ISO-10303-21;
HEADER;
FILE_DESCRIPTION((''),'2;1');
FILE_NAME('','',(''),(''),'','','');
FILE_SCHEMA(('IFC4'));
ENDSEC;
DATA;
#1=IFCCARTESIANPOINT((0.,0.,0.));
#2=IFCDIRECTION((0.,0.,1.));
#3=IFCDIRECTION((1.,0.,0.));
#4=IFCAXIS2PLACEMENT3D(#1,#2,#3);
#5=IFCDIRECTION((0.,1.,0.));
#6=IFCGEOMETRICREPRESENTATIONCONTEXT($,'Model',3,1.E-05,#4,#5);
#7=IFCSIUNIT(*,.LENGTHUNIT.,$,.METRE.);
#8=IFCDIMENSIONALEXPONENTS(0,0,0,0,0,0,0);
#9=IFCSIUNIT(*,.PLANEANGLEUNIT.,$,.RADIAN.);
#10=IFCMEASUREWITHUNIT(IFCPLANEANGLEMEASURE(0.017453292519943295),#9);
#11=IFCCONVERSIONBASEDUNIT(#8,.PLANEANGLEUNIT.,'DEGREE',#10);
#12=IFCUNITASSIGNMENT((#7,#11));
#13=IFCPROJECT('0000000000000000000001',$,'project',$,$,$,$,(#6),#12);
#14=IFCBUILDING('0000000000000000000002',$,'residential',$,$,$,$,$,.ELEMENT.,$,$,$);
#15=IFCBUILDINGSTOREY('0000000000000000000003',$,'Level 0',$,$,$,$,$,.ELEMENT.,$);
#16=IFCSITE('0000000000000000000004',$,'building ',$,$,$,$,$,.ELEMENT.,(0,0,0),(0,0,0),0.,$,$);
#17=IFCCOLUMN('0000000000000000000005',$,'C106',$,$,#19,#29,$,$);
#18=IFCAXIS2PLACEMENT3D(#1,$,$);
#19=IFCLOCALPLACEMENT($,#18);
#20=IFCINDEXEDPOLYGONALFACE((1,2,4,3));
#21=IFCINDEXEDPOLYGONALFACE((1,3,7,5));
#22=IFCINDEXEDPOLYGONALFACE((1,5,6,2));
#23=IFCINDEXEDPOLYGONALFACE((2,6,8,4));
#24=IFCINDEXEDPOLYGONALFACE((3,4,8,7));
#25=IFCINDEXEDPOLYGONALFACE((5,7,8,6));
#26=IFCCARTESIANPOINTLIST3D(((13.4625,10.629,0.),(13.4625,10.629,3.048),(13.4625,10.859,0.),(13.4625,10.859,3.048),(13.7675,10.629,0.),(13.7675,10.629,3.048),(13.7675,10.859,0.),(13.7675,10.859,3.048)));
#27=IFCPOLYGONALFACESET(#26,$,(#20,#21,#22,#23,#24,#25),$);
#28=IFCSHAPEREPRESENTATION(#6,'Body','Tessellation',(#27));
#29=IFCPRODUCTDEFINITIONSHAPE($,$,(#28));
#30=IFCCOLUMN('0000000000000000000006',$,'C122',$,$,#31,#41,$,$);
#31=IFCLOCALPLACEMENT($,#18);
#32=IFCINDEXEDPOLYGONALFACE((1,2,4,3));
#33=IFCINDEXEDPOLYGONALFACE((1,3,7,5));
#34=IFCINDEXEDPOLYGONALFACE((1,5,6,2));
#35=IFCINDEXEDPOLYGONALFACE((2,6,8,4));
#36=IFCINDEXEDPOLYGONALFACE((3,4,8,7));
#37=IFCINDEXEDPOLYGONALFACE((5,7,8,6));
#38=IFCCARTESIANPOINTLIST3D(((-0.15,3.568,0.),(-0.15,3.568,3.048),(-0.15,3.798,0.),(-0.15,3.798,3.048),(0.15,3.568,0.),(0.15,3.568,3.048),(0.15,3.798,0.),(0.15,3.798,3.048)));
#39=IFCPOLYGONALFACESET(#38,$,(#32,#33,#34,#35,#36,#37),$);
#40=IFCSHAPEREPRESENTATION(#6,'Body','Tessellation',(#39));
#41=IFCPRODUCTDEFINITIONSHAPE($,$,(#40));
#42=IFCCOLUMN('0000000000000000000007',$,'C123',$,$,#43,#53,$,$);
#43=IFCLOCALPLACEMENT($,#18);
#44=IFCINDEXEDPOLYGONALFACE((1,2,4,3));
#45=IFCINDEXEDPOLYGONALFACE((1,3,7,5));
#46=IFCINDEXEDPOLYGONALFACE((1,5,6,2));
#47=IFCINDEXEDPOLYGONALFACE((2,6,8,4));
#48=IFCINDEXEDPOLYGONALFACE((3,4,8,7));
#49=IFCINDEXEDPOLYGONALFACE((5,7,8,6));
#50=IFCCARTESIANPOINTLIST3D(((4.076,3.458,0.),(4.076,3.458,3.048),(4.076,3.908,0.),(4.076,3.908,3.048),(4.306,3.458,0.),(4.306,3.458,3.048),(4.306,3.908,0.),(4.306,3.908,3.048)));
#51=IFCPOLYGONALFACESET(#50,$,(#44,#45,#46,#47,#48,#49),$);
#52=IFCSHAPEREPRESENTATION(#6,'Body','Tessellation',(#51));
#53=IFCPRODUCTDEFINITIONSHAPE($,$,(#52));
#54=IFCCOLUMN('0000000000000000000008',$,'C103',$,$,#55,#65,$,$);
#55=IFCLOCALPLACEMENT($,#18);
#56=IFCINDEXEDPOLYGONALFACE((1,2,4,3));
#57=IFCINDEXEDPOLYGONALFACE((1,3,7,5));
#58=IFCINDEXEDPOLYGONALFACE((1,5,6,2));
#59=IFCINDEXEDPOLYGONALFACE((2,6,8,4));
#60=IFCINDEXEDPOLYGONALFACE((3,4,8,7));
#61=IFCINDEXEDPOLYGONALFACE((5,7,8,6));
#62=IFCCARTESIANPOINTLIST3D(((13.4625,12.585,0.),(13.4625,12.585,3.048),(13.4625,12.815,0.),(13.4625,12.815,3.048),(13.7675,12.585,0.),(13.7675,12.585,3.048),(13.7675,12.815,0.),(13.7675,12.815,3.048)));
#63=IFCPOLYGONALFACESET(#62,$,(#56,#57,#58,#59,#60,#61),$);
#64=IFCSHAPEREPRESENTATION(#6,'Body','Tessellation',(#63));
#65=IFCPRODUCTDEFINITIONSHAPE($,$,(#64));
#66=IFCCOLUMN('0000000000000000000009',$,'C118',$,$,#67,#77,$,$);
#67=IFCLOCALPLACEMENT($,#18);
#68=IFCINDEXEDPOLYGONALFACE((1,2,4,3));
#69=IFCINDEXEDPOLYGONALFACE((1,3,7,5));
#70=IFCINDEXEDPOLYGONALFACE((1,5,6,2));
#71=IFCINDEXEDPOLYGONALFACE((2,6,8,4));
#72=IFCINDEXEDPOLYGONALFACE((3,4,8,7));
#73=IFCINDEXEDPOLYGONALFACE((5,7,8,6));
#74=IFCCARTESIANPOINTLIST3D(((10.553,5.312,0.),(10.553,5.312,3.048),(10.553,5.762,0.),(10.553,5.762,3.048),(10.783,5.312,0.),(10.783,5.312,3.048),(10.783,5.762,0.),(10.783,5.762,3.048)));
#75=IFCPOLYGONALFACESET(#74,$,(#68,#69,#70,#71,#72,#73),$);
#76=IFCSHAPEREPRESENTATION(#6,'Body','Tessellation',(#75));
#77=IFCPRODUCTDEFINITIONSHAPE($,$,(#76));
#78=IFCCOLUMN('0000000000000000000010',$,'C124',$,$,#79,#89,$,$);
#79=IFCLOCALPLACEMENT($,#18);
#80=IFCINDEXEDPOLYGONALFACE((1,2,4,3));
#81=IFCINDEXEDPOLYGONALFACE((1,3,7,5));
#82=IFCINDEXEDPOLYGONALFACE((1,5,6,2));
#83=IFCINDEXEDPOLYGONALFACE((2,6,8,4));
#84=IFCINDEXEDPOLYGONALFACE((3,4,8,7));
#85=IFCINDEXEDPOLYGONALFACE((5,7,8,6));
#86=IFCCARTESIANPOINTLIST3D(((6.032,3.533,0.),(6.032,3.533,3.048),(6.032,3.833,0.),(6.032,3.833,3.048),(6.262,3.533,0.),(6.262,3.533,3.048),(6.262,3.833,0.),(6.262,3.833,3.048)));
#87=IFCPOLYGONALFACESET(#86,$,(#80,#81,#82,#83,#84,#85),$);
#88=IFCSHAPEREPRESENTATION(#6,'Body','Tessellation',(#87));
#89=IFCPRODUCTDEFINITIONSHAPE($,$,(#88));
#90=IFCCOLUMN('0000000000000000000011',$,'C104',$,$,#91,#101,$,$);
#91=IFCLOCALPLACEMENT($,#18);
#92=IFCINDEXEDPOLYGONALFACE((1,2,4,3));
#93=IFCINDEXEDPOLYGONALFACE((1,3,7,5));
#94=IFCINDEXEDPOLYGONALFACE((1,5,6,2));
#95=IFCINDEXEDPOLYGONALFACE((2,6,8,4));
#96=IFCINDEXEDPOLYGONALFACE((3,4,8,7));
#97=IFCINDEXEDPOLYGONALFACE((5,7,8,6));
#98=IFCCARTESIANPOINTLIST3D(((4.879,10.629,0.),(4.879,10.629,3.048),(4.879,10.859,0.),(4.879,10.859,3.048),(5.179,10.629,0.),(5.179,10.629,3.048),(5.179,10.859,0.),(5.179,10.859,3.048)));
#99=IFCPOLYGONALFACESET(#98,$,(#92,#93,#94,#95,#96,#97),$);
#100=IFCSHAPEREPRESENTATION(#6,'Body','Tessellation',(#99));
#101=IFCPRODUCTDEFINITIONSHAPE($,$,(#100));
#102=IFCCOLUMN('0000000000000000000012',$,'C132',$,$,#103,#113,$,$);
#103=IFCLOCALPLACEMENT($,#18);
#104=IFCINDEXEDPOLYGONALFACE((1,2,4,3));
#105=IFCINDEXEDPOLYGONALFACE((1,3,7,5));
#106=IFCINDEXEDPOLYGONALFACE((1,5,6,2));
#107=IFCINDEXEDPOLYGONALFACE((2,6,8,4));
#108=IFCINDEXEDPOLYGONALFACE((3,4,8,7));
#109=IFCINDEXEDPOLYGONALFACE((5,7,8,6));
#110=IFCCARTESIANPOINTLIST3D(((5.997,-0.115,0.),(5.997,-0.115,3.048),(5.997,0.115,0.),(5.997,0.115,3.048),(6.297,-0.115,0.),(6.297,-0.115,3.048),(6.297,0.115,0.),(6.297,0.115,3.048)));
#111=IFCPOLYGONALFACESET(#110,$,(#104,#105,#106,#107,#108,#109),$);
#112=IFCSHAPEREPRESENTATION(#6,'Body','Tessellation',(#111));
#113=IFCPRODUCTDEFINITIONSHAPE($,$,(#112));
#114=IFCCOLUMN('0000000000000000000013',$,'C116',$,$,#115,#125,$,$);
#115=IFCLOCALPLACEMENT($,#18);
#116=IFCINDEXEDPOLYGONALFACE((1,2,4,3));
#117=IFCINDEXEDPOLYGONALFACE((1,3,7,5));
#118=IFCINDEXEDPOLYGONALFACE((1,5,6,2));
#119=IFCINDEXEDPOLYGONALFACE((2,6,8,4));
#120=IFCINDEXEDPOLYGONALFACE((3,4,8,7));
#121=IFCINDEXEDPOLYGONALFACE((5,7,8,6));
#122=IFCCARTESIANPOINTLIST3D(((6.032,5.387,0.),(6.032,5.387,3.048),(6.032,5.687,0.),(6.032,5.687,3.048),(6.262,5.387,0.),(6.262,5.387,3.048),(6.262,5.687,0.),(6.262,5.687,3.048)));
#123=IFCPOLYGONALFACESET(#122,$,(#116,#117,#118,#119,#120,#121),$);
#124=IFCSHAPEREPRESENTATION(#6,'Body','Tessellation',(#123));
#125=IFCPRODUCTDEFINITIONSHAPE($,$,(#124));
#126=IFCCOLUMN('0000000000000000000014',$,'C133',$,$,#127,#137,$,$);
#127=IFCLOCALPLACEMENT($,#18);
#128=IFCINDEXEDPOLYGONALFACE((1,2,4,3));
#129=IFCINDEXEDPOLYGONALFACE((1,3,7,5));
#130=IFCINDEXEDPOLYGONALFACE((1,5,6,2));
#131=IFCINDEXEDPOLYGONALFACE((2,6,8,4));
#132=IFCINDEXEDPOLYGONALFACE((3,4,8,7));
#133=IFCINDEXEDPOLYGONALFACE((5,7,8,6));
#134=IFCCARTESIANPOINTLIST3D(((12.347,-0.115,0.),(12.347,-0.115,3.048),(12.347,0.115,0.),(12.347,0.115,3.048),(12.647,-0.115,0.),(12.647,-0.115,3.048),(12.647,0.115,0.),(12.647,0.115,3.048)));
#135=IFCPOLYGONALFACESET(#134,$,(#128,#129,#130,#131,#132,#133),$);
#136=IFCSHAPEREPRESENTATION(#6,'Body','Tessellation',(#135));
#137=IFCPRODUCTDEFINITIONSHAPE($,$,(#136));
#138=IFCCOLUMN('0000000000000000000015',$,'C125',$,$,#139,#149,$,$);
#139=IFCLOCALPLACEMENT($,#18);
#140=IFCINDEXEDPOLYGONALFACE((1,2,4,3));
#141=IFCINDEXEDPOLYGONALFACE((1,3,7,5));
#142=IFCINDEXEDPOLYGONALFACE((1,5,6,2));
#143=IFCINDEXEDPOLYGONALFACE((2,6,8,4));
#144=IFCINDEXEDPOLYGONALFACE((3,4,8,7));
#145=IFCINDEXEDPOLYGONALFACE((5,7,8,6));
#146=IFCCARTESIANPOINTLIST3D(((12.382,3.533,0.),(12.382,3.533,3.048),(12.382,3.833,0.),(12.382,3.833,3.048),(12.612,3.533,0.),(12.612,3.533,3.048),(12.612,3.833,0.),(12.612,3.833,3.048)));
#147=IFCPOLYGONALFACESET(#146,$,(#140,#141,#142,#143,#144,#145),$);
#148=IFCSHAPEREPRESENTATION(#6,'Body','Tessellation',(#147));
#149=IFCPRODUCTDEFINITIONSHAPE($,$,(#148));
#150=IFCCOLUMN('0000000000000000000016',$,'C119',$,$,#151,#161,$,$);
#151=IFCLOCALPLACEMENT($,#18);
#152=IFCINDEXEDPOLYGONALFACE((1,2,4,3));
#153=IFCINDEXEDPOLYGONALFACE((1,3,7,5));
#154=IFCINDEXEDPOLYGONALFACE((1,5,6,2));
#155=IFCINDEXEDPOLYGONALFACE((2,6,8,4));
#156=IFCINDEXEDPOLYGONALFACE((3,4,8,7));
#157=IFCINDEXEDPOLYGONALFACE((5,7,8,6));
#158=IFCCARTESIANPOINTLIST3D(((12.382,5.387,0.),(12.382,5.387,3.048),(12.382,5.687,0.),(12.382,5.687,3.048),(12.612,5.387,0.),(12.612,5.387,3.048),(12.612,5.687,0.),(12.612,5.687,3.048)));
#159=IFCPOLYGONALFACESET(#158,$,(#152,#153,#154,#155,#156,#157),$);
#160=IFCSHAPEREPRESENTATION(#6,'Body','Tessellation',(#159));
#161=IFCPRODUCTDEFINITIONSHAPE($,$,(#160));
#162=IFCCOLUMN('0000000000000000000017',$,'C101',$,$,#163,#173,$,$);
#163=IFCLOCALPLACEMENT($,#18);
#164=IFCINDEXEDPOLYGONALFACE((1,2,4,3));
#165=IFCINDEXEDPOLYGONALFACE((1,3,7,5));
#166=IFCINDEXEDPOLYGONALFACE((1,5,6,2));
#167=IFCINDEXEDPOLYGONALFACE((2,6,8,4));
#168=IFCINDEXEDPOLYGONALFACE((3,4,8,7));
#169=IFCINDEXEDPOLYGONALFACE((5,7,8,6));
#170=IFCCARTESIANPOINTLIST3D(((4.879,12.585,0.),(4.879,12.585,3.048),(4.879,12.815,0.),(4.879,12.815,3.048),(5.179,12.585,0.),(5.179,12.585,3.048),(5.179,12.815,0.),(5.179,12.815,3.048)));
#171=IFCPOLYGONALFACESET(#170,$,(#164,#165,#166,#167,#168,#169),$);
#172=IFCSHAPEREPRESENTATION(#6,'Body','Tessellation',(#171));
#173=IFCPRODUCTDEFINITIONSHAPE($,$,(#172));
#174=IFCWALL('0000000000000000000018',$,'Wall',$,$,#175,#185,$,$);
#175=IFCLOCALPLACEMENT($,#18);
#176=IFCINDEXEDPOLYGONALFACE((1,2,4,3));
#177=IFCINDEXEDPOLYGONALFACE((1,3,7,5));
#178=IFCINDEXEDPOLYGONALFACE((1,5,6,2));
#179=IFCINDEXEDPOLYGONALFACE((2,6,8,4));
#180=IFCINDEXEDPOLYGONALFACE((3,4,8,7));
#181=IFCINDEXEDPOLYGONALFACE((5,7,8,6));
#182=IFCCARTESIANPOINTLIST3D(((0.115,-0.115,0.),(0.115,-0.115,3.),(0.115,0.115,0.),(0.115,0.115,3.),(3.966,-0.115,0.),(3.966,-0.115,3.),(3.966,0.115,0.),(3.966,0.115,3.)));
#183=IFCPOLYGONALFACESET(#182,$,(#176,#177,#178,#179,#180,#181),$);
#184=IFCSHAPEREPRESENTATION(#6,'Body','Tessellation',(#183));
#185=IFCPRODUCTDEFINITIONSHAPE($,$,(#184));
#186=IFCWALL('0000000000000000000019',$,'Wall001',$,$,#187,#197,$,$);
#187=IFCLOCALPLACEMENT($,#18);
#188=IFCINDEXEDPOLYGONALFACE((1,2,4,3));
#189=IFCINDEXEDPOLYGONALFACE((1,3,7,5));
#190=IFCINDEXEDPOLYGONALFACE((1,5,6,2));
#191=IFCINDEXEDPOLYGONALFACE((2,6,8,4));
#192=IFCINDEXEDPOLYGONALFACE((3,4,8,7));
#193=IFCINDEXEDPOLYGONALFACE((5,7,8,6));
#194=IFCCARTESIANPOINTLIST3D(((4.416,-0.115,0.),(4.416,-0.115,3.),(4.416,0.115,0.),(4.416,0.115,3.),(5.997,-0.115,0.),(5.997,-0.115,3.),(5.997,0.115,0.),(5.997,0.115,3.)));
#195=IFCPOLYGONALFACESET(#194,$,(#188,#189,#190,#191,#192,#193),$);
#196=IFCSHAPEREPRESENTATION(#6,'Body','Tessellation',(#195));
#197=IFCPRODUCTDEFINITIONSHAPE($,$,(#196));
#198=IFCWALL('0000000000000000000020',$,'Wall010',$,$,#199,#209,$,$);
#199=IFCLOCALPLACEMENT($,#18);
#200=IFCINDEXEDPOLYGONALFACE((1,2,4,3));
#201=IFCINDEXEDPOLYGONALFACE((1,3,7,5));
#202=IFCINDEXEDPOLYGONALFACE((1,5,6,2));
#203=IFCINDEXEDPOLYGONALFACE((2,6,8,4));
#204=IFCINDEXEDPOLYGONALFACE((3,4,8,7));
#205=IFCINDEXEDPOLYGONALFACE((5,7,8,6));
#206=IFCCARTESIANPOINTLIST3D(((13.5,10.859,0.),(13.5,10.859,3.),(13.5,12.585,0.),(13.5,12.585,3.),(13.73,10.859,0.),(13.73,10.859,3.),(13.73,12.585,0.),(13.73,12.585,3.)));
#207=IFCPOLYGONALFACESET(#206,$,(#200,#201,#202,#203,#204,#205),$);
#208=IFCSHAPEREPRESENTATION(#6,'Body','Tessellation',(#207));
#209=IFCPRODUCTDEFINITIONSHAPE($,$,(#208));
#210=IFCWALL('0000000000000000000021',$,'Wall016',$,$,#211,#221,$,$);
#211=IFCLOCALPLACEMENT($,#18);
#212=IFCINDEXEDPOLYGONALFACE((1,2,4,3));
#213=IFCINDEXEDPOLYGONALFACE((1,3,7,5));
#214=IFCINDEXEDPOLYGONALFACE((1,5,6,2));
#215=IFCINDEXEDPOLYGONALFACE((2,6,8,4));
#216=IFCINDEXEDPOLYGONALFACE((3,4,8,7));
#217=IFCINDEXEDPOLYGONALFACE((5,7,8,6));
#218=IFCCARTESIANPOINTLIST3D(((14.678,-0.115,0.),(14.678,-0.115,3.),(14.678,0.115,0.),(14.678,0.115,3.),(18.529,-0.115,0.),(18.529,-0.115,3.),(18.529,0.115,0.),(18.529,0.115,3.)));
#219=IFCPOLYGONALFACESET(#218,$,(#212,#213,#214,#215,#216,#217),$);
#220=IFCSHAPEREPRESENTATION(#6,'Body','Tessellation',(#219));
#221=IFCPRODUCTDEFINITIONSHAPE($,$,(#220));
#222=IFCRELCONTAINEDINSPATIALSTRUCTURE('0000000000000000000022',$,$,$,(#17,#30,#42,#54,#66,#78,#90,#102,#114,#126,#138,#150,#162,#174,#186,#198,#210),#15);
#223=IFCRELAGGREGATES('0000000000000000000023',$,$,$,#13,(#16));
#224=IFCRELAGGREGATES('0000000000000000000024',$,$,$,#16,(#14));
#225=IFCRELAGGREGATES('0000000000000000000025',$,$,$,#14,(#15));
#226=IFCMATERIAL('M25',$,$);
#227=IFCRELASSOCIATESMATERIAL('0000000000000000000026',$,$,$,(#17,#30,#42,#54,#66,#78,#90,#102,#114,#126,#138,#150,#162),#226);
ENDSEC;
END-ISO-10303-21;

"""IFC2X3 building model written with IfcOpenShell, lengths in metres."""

from ifc_helpers import new_model, entity, si_unit, converted_unit, direction, frame, frame_2d, origin_with_axes, place, context, project, spatial, rectangle, extrude, material, element, save


model = new_model("IFC2X3")

# Units and contexts
model_context = context("Model", 3, precision=1e-05, world=origin_with_axes(), true_north=direction((0.0, 1.0, 0.0)))
ifc_project = project(units=[si_unit("LENGTHUNIT", "METRE"), converted_unit("PLANEANGLEUNIT", "DEGREE", entity("IfcPlaneAngleMeasure", 0.017453292519943295), si_unit("PLANEANGLEUNIT", "RADIAN"), dimensions=[0, 0, 0, 0, 0, 0, 0])], contexts=[model_context])

# Site, building, storey
site = spatial("IfcSite", under=ifc_project, Name="building ", CompositionType="ELEMENT", RefLatitude=(0, 0, 0), RefLongitude=(0, 0, 0), RefElevation=0.0)
building = spatial("IfcBuilding", under=site, Name="residential", CompositionType="ELEMENT")
storey = spatial("IfcBuildingStorey", under=building, Name="Level 0", CompositionType="ELEMENT")

# Columns
ifc_material = material(Name="M25")
placement = place(None, origin_with_axes())
element("IfcColumn", 1, at=placement, inside=storey, material=ifc_material, Name="C106", context=model_context, shape_type="SweptSolid", body=[
    extrude(rectangle(XDim=0.305, YDim=0.23, at=frame_2d((0.0, 0.0), x_axis=(1.0, 0.0, 0.0))), frame((13.615, 10.744, 0.0), z_axis=(0.0, 0.0, 1.0), x_axis=(1.0, 0.0, 0.0)), (0.0, 0.0, 1.0), 3.048),
])
element("IfcColumn", 2, at=placement, inside=storey, material=ifc_material, Name="C122", context=model_context, shape_type="SweptSolid", body=[
    extrude(rectangle(XDim=0.3, YDim=0.23, at=frame_2d((0.0, 0.0), x_axis=(1.0, 0.0, 0.0))), frame((0.0, 3.683, 0.0), z_axis=(0.0, 0.0, 1.0), x_axis=(1.0, 0.0, 0.0)), (0.0, 0.0, 1.0), 3.048),
])
element("IfcColumn", 3, at=placement, inside=storey, material=ifc_material, Name="C123", context=model_context, shape_type="SweptSolid", body=[
    extrude(rectangle(XDim=0.23, YDim=0.45, at=frame_2d((0.0, 0.0), x_axis=(1.0, 0.0, 0.0))), frame((4.191, 3.683, 0.0), z_axis=(0.0, 0.0, 1.0), x_axis=(1.0, 0.0, 0.0)), (0.0, 0.0, 1.0), 3.048),
])
element("IfcColumn", 4, at=placement, inside=storey, material=ifc_material, Name="C103", context=model_context, shape_type="SweptSolid", body=[
    extrude(rectangle(XDim=0.305, YDim=0.23, at=frame_2d((0.0, 0.0), x_axis=(1.0, 0.0, 0.0))), frame((13.615, 12.7, 0.0), z_axis=(0.0, 0.0, 1.0), x_axis=(1.0, 0.0, 0.0)), (0.0, 0.0, 1.0), 3.048),
])
element("IfcColumn", 5, at=placement, inside=storey, material=ifc_material, Name="C118", context=model_context, shape_type="SweptSolid", body=[
    extrude(rectangle(XDim=0.23, YDim=0.45, at=frame_2d((0.0, 0.0), x_axis=(1.0, 0.0, 0.0))), frame((10.668, 5.537, 0.0), z_axis=(0.0, 0.0, 1.0), x_axis=(1.0, 0.0, 0.0)), (0.0, 0.0, 1.0), 3.048),
])
element("IfcColumn", 6, at=placement, inside=storey, material=ifc_material, Name="C124", context=model_context, shape_type="SweptSolid", body=[
    extrude(rectangle(XDim=0.23, YDim=0.3, at=frame_2d((0.0, 0.0), x_axis=(1.0, 0.0, 0.0))), frame((6.147, 3.683, 0.0), z_axis=(0.0, 0.0, 1.0), x_axis=(1.0, 0.0, 0.0)), (0.0, 0.0, 1.0), 3.048),
])
element("IfcColumn", 7, at=placement, inside=storey, material=ifc_material, Name="C104", context=model_context, shape_type="SweptSolid", body=[
    extrude(rectangle(XDim=0.3, YDim=0.23, at=frame_2d((0.0, 0.0), x_axis=(1.0, 0.0, 0.0))), frame((5.029, 10.744, 0.0), z_axis=(0.0, 0.0, 1.0), x_axis=(1.0, 0.0, 0.0)), (0.0, 0.0, 1.0), 3.048),
])
element("IfcColumn", 8, at=placement, inside=storey, material=ifc_material, Name="C132", context=model_context, shape_type="SweptSolid", body=[
    extrude(rectangle(XDim=0.3, YDim=0.23, at=frame_2d((0.0, 0.0), x_axis=(1.0, 0.0, 0.0))), frame((6.147, 0.0, 0.0), z_axis=(0.0, 0.0, 1.0), x_axis=(1.0, 0.0, 0.0)), (0.0, 0.0, 1.0), 3.048),
])
element("IfcColumn", 9, at=placement, inside=storey, material=ifc_material, Name="C116", context=model_context, shape_type="SweptSolid", body=[
    extrude(rectangle(XDim=0.23, YDim=0.3, at=frame_2d((0.0, 0.0), x_axis=(1.0, 0.0, 0.0))), frame((6.147, 5.537, 0.0), z_axis=(0.0, 0.0, 1.0), x_axis=(1.0, 0.0, 0.0)), (0.0, 0.0, 1.0), 3.048),
])
element("IfcColumn", 10, at=placement, inside=storey, material=ifc_material, Name="C133", context=model_context, shape_type="SweptSolid", body=[
    extrude(rectangle(XDim=0.3, YDim=0.23, at=frame_2d((0.0, 0.0), x_axis=(1.0, 0.0, 0.0))), frame((12.497, 0.0, 0.0), z_axis=(0.0, 0.0, 1.0), x_axis=(1.0, 0.0, 0.0)), (0.0, 0.0, 1.0), 3.048),
])
element("IfcColumn", 11, at=placement, inside=storey, material=ifc_material, Name="C125", context=model_context, shape_type="SweptSolid", body=[
    extrude(rectangle(XDim=0.23, YDim=0.3, at=frame_2d((0.0, 0.0), x_axis=(1.0, 0.0, 0.0))), frame((12.497, 3.683, 0.0), z_axis=(0.0, 0.0, 1.0), x_axis=(1.0, 0.0, 0.0)), (0.0, 0.0, 1.0), 3.048),
])
element("IfcColumn", 12, at=placement, inside=storey, material=ifc_material, Name="C119", context=model_context, shape_type="SweptSolid", body=[
    extrude(rectangle(XDim=0.23, YDim=0.3, at=frame_2d((0.0, 0.0), x_axis=(1.0, 0.0, 0.0))), frame((12.497, 5.537, 0.0), z_axis=(0.0, 0.0, 1.0), x_axis=(1.0, 0.0, 0.0)), (0.0, 0.0, 1.0), 3.048),
])
element("IfcColumn", 13, at=placement, inside=storey, material=ifc_material, Name="C101", context=model_context, shape_type="SweptSolid", body=[
    extrude(rectangle(XDim=0.3, YDim=0.23, at=frame_2d((0.0, 0.0), x_axis=(1.0, 0.0, 0.0))), frame((5.029, 12.7, 0.0), z_axis=(0.0, 0.0, 1.0), x_axis=(1.0, 0.0, 0.0)), (0.0, 0.0, 1.0), 3.048),
])

# Walls
element("IfcWall", 14, at=placement, inside=storey, Name="Wall", context=model_context, shape_type="SweptSolid", body=[
    extrude(rectangle(XDim=3.851, YDim=0.23, at=frame_2d((0.0, 0.0), x_axis=(1.0, 0.0, 0.0))), frame((2.0405, 0.0, 0.0), z_axis=(0.0, 0.0, 1.0), x_axis=(1.0, 0.0, 0.0)), (0.0, 0.0, 1.0), 3.0),
])
element("IfcWall", 15, at=placement, inside=storey, Name="Wall001", context=model_context, shape_type="SweptSolid", body=[
    extrude(rectangle(XDim=1.581, YDim=0.23, at=frame_2d((0.0, 0.0), x_axis=(1.0, 0.0, 0.0))), frame((5.2065, 0.0, 0.0), z_axis=(0.0, 0.0, 1.0), x_axis=(1.0, 0.0, 0.0)), (0.0, 0.0, 1.0), 3.0),
])
element("IfcWall", 16, at=placement, inside=storey, Name="Wall010", context=model_context, shape_type="SweptSolid", body=[
    extrude(rectangle(XDim=1.726, YDim=0.23, at=frame_2d((0.0, 0.0), x_axis=(0.0, -1.0, 0.0))), frame((13.615, 11.722, 0.0), z_axis=(0.0, 0.0, 1.0), x_axis=(1.0, 0.0, 0.0)), (0.0, 0.0, 1.0), 3.0),
])
element("IfcWall", 17, at=placement, inside=storey, Name="Wall016", context=model_context, shape_type="SweptSolid", body=[
    extrude(rectangle(XDim=3.851, YDim=0.23, at=frame_2d((0.0, 0.0), x_axis=(1.0, 0.0, 0.0))), frame((16.6035, 0.0, 0.0), z_axis=(0.0, 0.0, 1.0), x_axis=(1.0, 0.0, 0.0)), (0.0, 0.0, 1.0), 3.0),
])

save(model, "model.ifc")
